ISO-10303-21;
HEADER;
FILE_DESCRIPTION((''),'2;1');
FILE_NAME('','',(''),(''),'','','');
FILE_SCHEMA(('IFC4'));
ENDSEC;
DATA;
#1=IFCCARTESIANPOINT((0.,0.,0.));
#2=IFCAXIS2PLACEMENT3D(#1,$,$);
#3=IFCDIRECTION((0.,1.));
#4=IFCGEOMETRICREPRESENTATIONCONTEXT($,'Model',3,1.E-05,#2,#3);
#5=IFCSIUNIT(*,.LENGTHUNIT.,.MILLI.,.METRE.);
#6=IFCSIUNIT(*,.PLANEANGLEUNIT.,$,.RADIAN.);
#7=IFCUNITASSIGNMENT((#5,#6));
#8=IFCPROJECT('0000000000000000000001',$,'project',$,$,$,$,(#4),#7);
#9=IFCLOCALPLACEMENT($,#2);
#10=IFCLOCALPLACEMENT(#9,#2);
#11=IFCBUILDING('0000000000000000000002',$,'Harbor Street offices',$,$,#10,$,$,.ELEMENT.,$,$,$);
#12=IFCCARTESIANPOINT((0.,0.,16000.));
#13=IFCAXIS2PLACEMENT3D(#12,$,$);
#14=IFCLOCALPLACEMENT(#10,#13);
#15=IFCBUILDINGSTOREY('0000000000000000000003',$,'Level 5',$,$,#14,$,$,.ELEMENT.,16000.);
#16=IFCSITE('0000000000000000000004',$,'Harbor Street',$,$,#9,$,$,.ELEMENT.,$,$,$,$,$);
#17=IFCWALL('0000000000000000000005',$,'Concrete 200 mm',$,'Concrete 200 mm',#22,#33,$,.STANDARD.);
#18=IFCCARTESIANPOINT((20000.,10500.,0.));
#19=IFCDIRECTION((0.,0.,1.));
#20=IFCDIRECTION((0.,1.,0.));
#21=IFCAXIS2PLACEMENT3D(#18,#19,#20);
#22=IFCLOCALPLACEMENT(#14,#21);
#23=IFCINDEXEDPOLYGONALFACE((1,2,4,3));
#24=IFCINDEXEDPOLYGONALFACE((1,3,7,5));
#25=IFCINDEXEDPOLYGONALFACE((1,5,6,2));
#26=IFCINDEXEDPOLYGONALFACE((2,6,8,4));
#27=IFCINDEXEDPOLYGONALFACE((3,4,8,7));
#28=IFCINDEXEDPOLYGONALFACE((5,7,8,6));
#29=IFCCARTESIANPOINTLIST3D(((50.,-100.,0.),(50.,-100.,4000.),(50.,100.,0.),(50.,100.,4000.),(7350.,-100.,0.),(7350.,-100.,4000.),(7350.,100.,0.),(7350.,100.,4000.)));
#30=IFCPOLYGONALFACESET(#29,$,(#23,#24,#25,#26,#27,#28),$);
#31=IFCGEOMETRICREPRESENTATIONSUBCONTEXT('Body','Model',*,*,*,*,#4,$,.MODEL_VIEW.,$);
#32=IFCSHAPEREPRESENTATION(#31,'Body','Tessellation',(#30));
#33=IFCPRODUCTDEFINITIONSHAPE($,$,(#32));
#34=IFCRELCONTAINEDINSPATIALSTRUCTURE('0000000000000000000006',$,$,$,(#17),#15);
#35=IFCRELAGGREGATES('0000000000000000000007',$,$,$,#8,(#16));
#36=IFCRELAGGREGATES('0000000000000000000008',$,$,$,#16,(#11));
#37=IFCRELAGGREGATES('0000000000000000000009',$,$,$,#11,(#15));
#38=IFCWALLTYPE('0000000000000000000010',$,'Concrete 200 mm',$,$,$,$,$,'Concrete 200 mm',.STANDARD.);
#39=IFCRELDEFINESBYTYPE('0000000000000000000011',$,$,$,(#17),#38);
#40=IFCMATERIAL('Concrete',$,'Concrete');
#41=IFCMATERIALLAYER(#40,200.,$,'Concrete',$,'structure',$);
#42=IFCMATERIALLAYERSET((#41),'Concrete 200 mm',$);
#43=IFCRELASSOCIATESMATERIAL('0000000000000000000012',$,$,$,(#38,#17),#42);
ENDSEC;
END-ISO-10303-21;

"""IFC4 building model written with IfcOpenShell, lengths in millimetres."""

from ifc_helpers import new_model, si_unit, direction, frame, origin, place, context, subcontext, project, spatial, polyline, outline, extrude, material, layer, layer_set, layer_usage, type_object, element, save


model = new_model("IFC4")

# Units and contexts
model_context = context("Model", 3, precision=1e-05, world=origin(), true_north=direction((0.0, 1.0)))
body_context = subcontext(model_context, "Body", "Model", "MODEL_VIEW")
ifc_project = project(units=[si_unit("LENGTHUNIT", "METRE", prefix="MILLI"), si_unit("PLANEANGLEUNIT", "RADIAN")], contexts=[model_context])

# Site, building, storey
site_placement = place(None, origin())
site = spatial("IfcSite", under=ifc_project, at=site_placement, Name="Harbor Street", CompositionType="ELEMENT")
building_placement = place(site_placement, origin())
building = spatial("IfcBuilding", under=site, at=building_placement, Name="Harbor Street offices", CompositionType="ELEMENT")
storey_placement = place(building_placement, frame((0.0, 0.0, 16000.0)))
storey = spatial("IfcBuildingStorey", under=building, at=storey_placement, Name="Level 5", CompositionType="ELEMENT", Elevation=16000.0)

# Shared definitions
ifc_material_1 = material(Name="Concrete", Category="Concrete")

# Wall
ifc_layer_1 = layer(ifc_material_1, 200.0, Name="Concrete", Category="structure")
ifc_layer_set_1 = layer_set([ifc_layer_1], Name="Concrete 200 mm")
ifc_layer_usage_1 = layer_usage(ifc_layer_set_1, "AXIS2", "NEGATIVE", 100.0)
wall_type_1 = type_object("IfcWallType", Name="Concrete 200 mm", ElementType="Concrete 200 mm", PredefinedType="STANDARD", material=ifc_layer_set_1)
wall_1_placement = place(storey_placement, frame((20000.0, 10500.0, 0.0), z_axis=(0.0, 0.0, 1.0), x_axis=(0.0, 1.0, 0.0)))
element("IfcWall", 1, at=wall_1_placement, inside=storey, type_object=wall_type_1, material=ifc_layer_usage_1, Name="Concrete 200 mm", ObjectType="Concrete 200 mm", PredefinedType="STANDARD", context=body_context, shape_type="SweptSolid", body=[
    extrude(outline(polyline([(50.0, -100.0), (7350.0, -100.0), (7350.0, 100.0), (50.0, 100.0), (50.0, -100.0)])), origin(), (0.0, 0.0, 1.0), 4000.0),
])

save(model, "model.ifc")
